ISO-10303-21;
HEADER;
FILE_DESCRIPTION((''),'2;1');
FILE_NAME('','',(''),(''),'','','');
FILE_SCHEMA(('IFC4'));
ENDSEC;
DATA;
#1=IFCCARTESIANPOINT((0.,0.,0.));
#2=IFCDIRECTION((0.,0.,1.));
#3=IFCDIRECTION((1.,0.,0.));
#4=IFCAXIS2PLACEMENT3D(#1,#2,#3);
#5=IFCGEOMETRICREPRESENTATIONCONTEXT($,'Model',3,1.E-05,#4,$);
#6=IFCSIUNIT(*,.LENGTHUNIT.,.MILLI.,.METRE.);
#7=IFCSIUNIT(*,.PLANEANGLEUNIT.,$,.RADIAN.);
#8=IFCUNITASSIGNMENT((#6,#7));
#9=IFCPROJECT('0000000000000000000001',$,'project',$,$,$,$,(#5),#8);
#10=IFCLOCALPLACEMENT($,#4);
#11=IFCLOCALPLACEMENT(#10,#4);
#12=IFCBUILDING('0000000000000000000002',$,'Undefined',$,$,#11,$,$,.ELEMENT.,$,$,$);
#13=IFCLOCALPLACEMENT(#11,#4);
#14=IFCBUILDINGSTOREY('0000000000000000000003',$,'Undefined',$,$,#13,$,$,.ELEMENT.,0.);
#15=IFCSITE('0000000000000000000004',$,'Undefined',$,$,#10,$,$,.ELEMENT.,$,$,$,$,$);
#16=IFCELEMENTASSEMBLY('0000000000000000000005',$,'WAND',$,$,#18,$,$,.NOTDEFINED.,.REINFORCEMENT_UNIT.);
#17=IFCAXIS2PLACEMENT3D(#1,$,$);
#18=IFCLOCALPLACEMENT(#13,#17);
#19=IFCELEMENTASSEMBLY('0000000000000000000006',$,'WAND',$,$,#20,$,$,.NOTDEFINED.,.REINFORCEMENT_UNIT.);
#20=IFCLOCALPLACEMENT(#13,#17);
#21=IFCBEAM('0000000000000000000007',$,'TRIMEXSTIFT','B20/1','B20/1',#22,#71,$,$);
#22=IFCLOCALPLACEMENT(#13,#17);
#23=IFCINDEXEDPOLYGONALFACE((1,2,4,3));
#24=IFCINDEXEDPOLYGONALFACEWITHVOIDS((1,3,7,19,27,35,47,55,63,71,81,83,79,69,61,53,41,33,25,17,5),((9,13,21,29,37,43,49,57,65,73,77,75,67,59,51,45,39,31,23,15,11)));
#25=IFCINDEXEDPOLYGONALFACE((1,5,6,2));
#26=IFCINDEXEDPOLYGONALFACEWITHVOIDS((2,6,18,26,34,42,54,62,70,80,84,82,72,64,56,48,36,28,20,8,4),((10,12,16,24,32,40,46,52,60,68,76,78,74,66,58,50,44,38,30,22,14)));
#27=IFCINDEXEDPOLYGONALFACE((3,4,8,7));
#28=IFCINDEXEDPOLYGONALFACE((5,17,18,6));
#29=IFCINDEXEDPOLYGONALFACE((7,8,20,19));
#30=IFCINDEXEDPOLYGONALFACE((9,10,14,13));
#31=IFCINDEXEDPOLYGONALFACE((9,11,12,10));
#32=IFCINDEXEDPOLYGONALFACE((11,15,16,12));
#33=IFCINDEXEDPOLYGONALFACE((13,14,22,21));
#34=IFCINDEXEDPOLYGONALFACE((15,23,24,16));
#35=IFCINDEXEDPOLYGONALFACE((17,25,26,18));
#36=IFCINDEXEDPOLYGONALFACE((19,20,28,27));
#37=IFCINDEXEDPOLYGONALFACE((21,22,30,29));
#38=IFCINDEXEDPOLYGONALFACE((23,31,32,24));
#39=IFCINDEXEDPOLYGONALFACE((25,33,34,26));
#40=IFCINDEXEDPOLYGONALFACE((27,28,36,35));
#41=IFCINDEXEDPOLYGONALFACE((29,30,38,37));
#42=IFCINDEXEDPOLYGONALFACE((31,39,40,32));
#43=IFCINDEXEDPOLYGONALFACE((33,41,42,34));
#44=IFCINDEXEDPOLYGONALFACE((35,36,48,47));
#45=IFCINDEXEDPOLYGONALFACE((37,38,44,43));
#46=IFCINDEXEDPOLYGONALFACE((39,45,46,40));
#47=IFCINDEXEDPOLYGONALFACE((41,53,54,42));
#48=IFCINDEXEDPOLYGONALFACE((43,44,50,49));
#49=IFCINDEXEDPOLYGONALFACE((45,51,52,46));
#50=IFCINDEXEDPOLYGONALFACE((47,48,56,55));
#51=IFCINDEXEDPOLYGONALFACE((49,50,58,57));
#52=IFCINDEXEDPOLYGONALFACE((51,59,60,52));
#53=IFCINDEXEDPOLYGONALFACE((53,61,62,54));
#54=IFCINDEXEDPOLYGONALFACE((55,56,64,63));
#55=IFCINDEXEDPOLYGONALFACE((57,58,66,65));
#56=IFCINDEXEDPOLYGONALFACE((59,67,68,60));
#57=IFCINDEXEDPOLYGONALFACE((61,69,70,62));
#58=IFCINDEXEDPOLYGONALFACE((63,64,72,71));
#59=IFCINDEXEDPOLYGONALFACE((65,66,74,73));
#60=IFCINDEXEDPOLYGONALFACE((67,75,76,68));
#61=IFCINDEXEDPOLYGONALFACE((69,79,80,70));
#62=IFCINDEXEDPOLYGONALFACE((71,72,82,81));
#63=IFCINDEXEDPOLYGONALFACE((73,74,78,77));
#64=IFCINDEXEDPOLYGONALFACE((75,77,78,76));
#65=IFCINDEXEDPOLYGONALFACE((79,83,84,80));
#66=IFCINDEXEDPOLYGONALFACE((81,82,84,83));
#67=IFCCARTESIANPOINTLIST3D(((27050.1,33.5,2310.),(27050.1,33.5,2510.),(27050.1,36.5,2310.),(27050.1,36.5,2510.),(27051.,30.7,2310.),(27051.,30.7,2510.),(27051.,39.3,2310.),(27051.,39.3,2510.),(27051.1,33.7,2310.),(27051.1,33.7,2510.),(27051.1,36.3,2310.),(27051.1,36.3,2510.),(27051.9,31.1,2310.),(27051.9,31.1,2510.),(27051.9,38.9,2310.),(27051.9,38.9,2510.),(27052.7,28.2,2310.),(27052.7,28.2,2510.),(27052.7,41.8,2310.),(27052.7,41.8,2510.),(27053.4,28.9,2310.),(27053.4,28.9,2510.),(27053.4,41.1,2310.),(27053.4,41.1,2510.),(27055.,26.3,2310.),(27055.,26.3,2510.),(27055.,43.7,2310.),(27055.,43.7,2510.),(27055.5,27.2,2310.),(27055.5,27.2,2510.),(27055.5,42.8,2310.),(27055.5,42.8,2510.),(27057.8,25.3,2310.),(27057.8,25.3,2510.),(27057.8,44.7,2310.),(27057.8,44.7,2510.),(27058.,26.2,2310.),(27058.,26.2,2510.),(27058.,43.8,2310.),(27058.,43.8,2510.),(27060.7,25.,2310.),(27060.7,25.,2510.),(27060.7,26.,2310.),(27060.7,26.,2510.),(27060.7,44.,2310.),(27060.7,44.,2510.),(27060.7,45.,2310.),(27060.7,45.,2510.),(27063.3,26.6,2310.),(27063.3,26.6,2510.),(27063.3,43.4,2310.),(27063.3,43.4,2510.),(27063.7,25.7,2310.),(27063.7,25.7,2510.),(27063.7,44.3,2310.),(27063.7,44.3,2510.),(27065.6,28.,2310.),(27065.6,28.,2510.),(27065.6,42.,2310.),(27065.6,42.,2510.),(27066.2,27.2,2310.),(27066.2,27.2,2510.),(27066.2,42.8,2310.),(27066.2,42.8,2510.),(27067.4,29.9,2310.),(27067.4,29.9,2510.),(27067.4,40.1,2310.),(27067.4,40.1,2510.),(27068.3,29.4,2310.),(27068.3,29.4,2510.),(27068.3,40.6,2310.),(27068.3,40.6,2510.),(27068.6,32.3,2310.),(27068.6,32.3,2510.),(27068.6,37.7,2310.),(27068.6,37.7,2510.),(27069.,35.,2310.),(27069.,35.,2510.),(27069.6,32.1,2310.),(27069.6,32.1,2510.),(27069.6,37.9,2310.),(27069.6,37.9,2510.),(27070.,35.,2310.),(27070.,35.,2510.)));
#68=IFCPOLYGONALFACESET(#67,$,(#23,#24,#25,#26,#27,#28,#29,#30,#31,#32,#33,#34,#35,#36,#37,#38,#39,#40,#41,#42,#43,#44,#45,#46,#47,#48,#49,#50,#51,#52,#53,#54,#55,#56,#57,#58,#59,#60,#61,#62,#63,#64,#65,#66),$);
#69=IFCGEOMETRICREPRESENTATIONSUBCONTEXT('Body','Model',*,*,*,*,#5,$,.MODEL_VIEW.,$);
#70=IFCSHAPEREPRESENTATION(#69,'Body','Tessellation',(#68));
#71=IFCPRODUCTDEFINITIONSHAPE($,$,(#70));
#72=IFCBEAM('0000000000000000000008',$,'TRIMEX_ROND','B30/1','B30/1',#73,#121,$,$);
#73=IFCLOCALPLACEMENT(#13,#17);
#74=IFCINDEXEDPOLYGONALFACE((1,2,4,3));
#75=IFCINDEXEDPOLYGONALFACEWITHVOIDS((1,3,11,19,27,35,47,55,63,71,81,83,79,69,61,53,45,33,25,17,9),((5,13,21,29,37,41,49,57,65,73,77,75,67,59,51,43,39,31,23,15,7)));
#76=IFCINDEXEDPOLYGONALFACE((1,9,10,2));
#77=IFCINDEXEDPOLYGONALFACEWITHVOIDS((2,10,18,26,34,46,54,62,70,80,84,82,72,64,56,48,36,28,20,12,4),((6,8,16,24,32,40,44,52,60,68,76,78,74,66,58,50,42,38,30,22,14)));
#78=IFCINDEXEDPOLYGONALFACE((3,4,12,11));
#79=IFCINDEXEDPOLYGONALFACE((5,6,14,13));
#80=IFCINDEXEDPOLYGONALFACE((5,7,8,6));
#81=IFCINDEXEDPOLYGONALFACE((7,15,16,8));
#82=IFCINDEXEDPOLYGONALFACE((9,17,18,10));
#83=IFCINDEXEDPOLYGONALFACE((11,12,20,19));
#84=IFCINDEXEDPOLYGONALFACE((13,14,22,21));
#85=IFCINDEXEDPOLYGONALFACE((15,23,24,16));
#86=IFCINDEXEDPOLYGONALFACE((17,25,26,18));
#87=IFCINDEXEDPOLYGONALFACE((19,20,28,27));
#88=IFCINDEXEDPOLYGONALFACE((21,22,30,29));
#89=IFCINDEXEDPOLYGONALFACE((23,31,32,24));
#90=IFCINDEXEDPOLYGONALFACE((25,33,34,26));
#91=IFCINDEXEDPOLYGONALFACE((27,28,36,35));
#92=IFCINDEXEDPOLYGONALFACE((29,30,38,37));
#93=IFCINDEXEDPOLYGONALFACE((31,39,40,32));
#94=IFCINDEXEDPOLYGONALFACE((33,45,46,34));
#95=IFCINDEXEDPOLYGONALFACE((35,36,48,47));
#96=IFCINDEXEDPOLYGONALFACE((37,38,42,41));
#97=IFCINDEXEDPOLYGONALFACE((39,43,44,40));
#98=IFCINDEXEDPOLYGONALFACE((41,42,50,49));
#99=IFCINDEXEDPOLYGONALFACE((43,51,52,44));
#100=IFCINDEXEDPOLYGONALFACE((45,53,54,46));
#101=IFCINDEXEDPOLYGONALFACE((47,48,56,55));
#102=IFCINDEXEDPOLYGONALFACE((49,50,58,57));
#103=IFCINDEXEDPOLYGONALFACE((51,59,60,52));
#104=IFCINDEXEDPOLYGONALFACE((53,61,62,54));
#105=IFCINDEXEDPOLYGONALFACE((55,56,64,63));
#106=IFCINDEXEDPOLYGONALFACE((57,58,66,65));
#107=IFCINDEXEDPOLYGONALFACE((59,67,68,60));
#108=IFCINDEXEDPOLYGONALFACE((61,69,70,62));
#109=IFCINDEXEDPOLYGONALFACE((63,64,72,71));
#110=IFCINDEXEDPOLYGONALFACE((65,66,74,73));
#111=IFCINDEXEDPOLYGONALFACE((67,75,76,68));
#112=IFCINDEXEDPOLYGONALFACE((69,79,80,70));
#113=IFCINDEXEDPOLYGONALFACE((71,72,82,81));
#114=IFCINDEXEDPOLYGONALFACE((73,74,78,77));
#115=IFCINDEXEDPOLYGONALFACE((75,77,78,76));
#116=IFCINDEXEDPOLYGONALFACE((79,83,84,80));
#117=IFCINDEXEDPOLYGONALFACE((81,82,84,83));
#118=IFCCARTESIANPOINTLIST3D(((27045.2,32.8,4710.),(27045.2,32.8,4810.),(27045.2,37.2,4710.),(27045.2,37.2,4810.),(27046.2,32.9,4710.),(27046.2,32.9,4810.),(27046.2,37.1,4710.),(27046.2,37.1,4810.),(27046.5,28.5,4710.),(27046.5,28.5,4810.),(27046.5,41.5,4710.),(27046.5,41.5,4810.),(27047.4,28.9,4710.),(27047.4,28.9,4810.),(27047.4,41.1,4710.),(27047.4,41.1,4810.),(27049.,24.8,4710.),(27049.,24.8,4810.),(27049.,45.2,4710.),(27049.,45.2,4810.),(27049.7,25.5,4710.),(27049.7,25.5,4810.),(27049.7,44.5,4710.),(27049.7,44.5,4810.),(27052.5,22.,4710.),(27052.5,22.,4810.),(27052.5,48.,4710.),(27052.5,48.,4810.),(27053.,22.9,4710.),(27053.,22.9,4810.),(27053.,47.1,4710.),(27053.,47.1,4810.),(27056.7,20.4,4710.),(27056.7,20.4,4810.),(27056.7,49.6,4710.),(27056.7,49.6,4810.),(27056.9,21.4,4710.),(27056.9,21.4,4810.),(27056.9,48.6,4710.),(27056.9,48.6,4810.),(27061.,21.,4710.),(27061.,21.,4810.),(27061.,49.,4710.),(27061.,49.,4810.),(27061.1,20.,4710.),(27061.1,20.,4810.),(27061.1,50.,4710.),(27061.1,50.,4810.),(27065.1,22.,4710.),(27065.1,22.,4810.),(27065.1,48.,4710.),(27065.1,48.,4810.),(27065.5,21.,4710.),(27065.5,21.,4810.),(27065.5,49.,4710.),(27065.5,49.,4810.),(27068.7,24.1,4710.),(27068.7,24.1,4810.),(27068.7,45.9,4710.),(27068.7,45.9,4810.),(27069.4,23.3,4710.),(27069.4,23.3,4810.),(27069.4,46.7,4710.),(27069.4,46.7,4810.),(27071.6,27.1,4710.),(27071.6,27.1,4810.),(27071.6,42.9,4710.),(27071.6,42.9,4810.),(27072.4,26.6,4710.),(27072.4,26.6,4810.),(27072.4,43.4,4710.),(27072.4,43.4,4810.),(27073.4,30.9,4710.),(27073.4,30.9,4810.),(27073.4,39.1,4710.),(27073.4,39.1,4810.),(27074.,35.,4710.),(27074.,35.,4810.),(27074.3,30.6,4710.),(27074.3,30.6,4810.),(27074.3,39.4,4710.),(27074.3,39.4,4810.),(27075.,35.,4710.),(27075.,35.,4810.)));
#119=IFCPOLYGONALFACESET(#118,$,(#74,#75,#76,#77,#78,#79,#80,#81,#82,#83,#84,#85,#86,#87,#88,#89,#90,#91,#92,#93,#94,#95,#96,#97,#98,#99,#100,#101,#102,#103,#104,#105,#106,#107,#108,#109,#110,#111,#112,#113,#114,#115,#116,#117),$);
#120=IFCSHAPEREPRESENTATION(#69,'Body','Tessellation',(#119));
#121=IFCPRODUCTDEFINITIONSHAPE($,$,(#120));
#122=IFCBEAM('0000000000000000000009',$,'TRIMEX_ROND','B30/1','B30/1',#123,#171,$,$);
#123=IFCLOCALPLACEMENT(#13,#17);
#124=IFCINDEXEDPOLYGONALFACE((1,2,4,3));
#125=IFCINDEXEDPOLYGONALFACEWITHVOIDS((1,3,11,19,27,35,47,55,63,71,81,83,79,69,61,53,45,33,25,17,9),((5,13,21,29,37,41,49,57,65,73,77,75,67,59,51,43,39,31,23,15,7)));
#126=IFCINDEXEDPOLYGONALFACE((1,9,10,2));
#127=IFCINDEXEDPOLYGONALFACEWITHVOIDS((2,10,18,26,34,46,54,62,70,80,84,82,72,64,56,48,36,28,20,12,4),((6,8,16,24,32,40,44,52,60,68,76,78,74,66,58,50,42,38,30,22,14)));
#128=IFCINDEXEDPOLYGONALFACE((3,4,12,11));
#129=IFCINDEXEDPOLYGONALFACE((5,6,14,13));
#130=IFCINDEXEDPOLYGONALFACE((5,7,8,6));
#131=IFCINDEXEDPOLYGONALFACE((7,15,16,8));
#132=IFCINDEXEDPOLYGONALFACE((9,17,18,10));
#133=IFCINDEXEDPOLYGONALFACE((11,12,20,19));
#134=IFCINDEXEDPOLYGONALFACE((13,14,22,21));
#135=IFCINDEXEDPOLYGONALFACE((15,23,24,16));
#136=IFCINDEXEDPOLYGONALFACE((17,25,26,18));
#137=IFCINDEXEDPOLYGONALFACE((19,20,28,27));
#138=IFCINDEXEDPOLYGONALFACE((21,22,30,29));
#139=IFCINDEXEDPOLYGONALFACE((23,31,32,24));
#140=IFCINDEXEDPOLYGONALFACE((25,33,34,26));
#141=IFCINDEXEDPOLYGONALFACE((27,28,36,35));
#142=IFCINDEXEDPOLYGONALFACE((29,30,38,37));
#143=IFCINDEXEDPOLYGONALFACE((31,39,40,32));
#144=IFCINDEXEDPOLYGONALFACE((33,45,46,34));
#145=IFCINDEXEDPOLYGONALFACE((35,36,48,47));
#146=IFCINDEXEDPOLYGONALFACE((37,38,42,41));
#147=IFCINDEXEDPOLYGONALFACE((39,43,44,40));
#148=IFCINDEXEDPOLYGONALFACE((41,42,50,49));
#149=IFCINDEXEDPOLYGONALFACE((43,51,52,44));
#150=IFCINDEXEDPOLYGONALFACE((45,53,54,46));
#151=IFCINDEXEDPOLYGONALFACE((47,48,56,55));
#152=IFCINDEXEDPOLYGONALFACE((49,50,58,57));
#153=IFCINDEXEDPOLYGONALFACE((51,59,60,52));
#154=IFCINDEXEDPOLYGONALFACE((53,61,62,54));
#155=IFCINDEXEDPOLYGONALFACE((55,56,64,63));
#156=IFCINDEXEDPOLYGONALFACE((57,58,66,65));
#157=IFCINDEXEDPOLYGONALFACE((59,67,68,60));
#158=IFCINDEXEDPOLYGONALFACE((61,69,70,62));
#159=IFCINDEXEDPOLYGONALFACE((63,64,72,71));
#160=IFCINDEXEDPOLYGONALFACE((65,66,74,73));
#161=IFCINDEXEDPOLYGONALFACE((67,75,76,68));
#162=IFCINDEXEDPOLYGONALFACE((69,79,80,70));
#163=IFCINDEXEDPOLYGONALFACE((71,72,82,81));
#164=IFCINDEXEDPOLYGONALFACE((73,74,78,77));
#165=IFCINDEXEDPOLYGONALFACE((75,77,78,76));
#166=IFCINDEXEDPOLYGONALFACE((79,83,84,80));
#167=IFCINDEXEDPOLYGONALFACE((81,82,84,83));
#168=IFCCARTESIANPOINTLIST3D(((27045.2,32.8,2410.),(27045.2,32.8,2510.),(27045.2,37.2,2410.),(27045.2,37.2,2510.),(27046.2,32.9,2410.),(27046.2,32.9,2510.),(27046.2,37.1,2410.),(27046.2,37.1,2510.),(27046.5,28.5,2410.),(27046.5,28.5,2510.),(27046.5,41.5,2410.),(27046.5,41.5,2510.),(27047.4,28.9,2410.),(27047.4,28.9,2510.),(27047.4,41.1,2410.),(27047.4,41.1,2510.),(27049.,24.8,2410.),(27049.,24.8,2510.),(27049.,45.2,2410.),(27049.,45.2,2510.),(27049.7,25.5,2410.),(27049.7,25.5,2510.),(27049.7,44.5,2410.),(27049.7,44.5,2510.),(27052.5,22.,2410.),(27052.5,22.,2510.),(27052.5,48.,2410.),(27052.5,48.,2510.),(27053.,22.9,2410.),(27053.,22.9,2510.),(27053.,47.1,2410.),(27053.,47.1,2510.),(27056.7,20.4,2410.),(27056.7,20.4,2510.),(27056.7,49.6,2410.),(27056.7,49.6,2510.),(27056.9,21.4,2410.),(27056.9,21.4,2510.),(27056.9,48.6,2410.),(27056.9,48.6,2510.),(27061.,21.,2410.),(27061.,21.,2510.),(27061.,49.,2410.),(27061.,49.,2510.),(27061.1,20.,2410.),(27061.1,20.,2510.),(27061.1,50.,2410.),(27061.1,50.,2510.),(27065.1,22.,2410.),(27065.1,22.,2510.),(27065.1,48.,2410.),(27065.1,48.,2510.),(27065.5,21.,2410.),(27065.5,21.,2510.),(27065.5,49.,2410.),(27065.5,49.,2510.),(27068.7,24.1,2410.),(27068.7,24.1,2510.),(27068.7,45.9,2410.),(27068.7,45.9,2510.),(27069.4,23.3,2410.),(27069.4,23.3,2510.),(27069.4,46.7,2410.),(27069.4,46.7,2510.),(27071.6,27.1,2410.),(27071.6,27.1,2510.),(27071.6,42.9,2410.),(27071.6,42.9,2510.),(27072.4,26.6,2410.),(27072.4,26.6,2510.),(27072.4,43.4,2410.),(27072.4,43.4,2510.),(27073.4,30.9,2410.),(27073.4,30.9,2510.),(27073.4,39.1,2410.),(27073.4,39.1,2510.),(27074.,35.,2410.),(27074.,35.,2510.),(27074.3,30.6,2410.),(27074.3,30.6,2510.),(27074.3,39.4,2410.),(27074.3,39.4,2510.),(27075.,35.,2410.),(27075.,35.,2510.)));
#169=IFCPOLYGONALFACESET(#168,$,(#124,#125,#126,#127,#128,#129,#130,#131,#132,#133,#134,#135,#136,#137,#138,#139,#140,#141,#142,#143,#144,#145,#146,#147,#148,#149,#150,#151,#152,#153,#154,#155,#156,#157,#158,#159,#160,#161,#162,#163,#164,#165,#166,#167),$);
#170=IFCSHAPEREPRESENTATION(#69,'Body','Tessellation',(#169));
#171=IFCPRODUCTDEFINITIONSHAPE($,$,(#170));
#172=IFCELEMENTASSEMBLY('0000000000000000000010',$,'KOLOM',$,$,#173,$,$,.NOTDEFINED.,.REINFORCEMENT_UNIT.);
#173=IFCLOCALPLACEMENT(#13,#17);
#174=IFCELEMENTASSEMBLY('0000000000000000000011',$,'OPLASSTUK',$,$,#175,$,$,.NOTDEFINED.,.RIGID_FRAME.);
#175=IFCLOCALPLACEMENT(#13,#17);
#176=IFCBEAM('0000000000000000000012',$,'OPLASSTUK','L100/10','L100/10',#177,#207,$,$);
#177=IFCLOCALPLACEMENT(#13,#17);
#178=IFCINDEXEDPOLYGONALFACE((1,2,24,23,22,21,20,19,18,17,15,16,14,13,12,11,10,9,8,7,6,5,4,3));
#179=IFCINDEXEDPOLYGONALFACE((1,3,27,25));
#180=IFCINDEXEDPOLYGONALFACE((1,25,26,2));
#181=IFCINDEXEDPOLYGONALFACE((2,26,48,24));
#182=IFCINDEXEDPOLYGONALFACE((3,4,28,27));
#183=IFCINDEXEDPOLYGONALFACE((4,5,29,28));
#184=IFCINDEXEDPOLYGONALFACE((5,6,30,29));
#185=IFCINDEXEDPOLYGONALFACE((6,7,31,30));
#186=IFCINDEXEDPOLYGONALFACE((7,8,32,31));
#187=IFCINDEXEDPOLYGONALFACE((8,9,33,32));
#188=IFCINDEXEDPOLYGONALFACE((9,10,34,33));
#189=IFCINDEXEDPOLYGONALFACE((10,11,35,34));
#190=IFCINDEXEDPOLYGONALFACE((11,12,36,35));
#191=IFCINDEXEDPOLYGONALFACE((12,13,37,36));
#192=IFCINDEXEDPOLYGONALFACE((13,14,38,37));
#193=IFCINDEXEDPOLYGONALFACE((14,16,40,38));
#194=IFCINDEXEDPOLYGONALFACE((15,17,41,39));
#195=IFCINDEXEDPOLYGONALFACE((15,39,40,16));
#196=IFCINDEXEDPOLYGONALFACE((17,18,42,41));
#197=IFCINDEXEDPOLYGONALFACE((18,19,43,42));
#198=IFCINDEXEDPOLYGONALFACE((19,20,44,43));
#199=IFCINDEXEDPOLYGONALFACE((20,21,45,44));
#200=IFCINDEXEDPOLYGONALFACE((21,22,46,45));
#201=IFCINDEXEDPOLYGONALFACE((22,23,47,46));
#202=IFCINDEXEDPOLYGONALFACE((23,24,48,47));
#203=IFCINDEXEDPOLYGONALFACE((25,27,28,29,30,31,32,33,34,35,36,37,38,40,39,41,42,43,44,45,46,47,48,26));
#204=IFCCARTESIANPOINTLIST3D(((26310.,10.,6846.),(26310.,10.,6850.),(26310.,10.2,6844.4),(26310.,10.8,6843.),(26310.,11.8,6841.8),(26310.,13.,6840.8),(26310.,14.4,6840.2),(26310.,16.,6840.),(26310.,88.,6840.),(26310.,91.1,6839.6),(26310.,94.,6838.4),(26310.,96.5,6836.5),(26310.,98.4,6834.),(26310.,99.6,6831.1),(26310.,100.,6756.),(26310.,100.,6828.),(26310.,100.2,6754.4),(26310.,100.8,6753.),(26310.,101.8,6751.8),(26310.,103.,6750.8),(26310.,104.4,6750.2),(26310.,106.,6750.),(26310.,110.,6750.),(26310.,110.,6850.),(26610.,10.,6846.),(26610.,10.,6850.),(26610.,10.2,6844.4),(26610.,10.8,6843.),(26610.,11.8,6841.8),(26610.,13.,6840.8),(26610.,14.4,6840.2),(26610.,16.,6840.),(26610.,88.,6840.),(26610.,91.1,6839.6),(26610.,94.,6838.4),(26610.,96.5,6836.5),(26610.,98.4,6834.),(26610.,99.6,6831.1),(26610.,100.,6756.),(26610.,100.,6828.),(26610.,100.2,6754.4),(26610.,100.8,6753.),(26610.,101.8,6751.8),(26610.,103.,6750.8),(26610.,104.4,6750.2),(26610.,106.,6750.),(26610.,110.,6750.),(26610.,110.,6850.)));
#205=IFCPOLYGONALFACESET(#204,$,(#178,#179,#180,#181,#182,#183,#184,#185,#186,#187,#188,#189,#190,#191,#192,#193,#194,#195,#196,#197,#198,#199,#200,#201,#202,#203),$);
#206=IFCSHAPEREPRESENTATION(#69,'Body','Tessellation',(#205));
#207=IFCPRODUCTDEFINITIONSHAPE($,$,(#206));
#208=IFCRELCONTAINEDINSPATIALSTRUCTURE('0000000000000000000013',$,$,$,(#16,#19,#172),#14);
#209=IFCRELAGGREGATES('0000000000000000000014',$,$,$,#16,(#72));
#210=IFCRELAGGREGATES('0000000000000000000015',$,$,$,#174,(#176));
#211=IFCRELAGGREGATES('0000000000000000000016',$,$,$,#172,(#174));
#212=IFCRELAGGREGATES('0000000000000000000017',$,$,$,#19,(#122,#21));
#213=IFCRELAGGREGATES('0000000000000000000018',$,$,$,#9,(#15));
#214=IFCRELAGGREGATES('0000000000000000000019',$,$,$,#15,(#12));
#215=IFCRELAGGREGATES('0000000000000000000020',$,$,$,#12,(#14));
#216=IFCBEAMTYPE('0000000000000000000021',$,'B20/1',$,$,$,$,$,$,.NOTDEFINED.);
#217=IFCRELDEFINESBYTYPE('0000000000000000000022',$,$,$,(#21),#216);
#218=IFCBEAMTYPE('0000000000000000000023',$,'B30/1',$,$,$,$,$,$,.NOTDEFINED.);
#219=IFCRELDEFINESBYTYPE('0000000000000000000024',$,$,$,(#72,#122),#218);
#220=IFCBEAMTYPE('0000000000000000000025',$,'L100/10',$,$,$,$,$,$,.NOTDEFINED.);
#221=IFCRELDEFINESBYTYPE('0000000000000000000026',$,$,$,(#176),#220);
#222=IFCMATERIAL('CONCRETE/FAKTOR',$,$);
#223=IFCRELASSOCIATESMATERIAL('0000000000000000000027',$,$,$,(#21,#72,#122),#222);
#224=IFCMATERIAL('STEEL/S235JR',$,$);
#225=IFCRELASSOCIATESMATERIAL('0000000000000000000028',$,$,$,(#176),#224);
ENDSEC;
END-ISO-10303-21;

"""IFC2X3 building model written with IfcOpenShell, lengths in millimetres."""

from ifc_helpers import new_model, si_unit, frame, frame_2d, origin_with_axes, place, context, subcontext, project, spatial, hollow_circle, l_section, extrude, material, type_object, element, aggregate, save


model = new_model("IFC2X3")

# Units and contexts
model_context = context("Model", 3, precision=1e-05, world=origin_with_axes())
body_context = subcontext(model_context, "Body", "Model", "MODEL_VIEW")
ifc_project = project(units=[si_unit("LENGTHUNIT", "METRE", prefix="MILLI"), si_unit("PLANEANGLEUNIT", "RADIAN")], contexts=[model_context])

# Site, building, storey
site_placement = place(None, origin_with_axes())
site = spatial("IfcSite", under=ifc_project, at=site_placement, Name="Undefined", CompositionType="ELEMENT")
building_placement = place(site_placement, origin_with_axes())
building = spatial("IfcBuilding", under=site, at=building_placement, Name="Undefined", CompositionType="ELEMENT")
storey_placement = place(building_placement, origin_with_axes())
storey = spatial("IfcBuildingStorey", under=building, at=storey_placement, Name="Undefined", CompositionType="ELEMENT", Elevation=0.0)

# Shared definitions
ifc_material_1 = material(Name="STEEL/S235JR")

# Element assembly
assembly_1_placement = place(storey_placement, origin_with_axes())
assembly_1 = element("IfcElementAssembly", 1, at=assembly_1_placement, inside=storey, Name="WAND", AssemblyPlace="NOTDEFINED", PredefinedType="REINFORCEMENT_UNIT")

# Element assembly
assembly_2_placement = place(storey_placement, origin_with_axes())
assembly_2 = element("IfcElementAssembly", 2, at=assembly_2_placement, inside=storey, Name="WAND", AssemblyPlace="NOTDEFINED", PredefinedType="REINFORCEMENT_UNIT")
ifc_material_2 = material(Name="CONCRETE/FAKTOR")
beam_type_1 = type_object("IfcBeamType", Name="B20/1", PredefinedType="NOTDEFINED")

# Beams
beam_1_placement = place(assembly_2_placement, frame((27060.0, 35.0, 2310.0), z_axis=(0.0, -1.0, 0.0), x_axis=(0.0, 0.0, 1.0)))
beam_1 = element("IfcBeam", 3, at=beam_1_placement, type_object=beam_type_1, material=ifc_material_2, Name="TRIMEXSTIFT", Description="B20/1", ObjectType="B20/1", context=body_context, shape_type="SweptSolid", body=[
    extrude(hollow_circle(Radius=10.0, WallThickness=1.0, at=frame_2d((0.0, 0.0), x_axis=(1.0, 0.0))), frame((200.0, 0.0, 0.0), z_axis=(-1.0, 0.0, 0.0), x_axis=(0.0, -1.0, 0.0)), (0.0, 0.0, 1.0), 200.0),
])
beam_type_2 = type_object("IfcBeamType", Name="B30/1", PredefinedType="NOTDEFINED")
beam_2_placement = place(assembly_1_placement, frame((27060.0, 35.0, 4710.0), z_axis=(0.0, -1.0, 0.0), x_axis=(0.0, 0.0, 1.0)))
beam_2 = element("IfcBeam", 4, at=beam_2_placement, type_object=beam_type_2, material=ifc_material_2, Name="TRIMEX_ROND", Description="B30/1", ObjectType="B30/1", context=body_context, shape_type="SweptSolid", body=[
    extrude(hollow_circle(Radius=15.0, WallThickness=1.0, at=frame_2d((0.0, 0.0), x_axis=(1.0, 0.0))), frame((100.0, 0.0, 0.0), z_axis=(-1.0, 0.0, 0.0), x_axis=(0.0, -1.0, 0.0)), (0.0, 0.0, 1.0), 100.0),
])
aggregate(assembly_1, [beam_2])
beam_3_placement = place(assembly_2_placement, frame((27060.0, 35.0, 2410.0), z_axis=(0.0, -1.0, 0.0), x_axis=(0.0, 0.0, 1.0)))
beam_3 = element("IfcBeam", 5, at=beam_3_placement, type_object=beam_type_2, material=ifc_material_2, Name="TRIMEX_ROND", Description="B30/1", ObjectType="B30/1", context=body_context, shape_type="SweptSolid", body=[
    extrude(hollow_circle(Radius=15.0, WallThickness=1.0, at=frame_2d((0.0, 0.0), x_axis=(1.0, 0.0))), frame((100.0, 0.0, 0.0), z_axis=(-1.0, 0.0, 0.0), x_axis=(0.0, -1.0, 0.0)), (0.0, 0.0, 1.0), 100.0),
])

# Element assemblies, beam
assembly_3_placement = place(storey_placement, origin_with_axes())
assembly_3 = element("IfcElementAssembly", 6, at=assembly_3_placement, inside=storey, Name="KOLOM", AssemblyPlace="NOTDEFINED", PredefinedType="REINFORCEMENT_UNIT")
assembly_4_placement = place(assembly_3_placement, origin_with_axes())
assembly_4 = element("IfcElementAssembly", 7, at=assembly_4_placement, Name="OPLASSTUK", AssemblyPlace="NOTDEFINED", PredefinedType="RIGID_FRAME")
beam_type_3 = type_object("IfcBeamType", Name="L100/10", PredefinedType="NOTDEFINED")
beam_4_placement = place(assembly_4_placement, frame((26610.0, 60.0, 6800.0), z_axis=(0.0, 0.0, -1.0), x_axis=(-1.0, 0.0, 0.0)))
beam_4 = element("IfcBeam", 8, at=beam_4_placement, type_object=beam_type_3, material=ifc_material_1, Name="OPLASSTUK", Description="L100/10", ObjectType="L100/10", context=body_context, shape_type="SweptSolid", body=[
    extrude(l_section(Depth=100.0, Width=100.0, Thickness=10.0, FilletRadius=12.0, EdgeRadius=6.0, at=frame_2d((0.0, 0.0), x_axis=(1.0, 0.0))), frame((300.0, 0.0, 0.0), z_axis=(-1.0, 0.0, 0.0), x_axis=(0.0, -1.0, 0.0)), (0.0, 0.0, 1.0), 300.0),
])
aggregate(assembly_4, [beam_4])

aggregate(assembly_3, [assembly_4])

aggregate(assembly_2, [beam_3, beam_1])

save(model, "model.ifc")
